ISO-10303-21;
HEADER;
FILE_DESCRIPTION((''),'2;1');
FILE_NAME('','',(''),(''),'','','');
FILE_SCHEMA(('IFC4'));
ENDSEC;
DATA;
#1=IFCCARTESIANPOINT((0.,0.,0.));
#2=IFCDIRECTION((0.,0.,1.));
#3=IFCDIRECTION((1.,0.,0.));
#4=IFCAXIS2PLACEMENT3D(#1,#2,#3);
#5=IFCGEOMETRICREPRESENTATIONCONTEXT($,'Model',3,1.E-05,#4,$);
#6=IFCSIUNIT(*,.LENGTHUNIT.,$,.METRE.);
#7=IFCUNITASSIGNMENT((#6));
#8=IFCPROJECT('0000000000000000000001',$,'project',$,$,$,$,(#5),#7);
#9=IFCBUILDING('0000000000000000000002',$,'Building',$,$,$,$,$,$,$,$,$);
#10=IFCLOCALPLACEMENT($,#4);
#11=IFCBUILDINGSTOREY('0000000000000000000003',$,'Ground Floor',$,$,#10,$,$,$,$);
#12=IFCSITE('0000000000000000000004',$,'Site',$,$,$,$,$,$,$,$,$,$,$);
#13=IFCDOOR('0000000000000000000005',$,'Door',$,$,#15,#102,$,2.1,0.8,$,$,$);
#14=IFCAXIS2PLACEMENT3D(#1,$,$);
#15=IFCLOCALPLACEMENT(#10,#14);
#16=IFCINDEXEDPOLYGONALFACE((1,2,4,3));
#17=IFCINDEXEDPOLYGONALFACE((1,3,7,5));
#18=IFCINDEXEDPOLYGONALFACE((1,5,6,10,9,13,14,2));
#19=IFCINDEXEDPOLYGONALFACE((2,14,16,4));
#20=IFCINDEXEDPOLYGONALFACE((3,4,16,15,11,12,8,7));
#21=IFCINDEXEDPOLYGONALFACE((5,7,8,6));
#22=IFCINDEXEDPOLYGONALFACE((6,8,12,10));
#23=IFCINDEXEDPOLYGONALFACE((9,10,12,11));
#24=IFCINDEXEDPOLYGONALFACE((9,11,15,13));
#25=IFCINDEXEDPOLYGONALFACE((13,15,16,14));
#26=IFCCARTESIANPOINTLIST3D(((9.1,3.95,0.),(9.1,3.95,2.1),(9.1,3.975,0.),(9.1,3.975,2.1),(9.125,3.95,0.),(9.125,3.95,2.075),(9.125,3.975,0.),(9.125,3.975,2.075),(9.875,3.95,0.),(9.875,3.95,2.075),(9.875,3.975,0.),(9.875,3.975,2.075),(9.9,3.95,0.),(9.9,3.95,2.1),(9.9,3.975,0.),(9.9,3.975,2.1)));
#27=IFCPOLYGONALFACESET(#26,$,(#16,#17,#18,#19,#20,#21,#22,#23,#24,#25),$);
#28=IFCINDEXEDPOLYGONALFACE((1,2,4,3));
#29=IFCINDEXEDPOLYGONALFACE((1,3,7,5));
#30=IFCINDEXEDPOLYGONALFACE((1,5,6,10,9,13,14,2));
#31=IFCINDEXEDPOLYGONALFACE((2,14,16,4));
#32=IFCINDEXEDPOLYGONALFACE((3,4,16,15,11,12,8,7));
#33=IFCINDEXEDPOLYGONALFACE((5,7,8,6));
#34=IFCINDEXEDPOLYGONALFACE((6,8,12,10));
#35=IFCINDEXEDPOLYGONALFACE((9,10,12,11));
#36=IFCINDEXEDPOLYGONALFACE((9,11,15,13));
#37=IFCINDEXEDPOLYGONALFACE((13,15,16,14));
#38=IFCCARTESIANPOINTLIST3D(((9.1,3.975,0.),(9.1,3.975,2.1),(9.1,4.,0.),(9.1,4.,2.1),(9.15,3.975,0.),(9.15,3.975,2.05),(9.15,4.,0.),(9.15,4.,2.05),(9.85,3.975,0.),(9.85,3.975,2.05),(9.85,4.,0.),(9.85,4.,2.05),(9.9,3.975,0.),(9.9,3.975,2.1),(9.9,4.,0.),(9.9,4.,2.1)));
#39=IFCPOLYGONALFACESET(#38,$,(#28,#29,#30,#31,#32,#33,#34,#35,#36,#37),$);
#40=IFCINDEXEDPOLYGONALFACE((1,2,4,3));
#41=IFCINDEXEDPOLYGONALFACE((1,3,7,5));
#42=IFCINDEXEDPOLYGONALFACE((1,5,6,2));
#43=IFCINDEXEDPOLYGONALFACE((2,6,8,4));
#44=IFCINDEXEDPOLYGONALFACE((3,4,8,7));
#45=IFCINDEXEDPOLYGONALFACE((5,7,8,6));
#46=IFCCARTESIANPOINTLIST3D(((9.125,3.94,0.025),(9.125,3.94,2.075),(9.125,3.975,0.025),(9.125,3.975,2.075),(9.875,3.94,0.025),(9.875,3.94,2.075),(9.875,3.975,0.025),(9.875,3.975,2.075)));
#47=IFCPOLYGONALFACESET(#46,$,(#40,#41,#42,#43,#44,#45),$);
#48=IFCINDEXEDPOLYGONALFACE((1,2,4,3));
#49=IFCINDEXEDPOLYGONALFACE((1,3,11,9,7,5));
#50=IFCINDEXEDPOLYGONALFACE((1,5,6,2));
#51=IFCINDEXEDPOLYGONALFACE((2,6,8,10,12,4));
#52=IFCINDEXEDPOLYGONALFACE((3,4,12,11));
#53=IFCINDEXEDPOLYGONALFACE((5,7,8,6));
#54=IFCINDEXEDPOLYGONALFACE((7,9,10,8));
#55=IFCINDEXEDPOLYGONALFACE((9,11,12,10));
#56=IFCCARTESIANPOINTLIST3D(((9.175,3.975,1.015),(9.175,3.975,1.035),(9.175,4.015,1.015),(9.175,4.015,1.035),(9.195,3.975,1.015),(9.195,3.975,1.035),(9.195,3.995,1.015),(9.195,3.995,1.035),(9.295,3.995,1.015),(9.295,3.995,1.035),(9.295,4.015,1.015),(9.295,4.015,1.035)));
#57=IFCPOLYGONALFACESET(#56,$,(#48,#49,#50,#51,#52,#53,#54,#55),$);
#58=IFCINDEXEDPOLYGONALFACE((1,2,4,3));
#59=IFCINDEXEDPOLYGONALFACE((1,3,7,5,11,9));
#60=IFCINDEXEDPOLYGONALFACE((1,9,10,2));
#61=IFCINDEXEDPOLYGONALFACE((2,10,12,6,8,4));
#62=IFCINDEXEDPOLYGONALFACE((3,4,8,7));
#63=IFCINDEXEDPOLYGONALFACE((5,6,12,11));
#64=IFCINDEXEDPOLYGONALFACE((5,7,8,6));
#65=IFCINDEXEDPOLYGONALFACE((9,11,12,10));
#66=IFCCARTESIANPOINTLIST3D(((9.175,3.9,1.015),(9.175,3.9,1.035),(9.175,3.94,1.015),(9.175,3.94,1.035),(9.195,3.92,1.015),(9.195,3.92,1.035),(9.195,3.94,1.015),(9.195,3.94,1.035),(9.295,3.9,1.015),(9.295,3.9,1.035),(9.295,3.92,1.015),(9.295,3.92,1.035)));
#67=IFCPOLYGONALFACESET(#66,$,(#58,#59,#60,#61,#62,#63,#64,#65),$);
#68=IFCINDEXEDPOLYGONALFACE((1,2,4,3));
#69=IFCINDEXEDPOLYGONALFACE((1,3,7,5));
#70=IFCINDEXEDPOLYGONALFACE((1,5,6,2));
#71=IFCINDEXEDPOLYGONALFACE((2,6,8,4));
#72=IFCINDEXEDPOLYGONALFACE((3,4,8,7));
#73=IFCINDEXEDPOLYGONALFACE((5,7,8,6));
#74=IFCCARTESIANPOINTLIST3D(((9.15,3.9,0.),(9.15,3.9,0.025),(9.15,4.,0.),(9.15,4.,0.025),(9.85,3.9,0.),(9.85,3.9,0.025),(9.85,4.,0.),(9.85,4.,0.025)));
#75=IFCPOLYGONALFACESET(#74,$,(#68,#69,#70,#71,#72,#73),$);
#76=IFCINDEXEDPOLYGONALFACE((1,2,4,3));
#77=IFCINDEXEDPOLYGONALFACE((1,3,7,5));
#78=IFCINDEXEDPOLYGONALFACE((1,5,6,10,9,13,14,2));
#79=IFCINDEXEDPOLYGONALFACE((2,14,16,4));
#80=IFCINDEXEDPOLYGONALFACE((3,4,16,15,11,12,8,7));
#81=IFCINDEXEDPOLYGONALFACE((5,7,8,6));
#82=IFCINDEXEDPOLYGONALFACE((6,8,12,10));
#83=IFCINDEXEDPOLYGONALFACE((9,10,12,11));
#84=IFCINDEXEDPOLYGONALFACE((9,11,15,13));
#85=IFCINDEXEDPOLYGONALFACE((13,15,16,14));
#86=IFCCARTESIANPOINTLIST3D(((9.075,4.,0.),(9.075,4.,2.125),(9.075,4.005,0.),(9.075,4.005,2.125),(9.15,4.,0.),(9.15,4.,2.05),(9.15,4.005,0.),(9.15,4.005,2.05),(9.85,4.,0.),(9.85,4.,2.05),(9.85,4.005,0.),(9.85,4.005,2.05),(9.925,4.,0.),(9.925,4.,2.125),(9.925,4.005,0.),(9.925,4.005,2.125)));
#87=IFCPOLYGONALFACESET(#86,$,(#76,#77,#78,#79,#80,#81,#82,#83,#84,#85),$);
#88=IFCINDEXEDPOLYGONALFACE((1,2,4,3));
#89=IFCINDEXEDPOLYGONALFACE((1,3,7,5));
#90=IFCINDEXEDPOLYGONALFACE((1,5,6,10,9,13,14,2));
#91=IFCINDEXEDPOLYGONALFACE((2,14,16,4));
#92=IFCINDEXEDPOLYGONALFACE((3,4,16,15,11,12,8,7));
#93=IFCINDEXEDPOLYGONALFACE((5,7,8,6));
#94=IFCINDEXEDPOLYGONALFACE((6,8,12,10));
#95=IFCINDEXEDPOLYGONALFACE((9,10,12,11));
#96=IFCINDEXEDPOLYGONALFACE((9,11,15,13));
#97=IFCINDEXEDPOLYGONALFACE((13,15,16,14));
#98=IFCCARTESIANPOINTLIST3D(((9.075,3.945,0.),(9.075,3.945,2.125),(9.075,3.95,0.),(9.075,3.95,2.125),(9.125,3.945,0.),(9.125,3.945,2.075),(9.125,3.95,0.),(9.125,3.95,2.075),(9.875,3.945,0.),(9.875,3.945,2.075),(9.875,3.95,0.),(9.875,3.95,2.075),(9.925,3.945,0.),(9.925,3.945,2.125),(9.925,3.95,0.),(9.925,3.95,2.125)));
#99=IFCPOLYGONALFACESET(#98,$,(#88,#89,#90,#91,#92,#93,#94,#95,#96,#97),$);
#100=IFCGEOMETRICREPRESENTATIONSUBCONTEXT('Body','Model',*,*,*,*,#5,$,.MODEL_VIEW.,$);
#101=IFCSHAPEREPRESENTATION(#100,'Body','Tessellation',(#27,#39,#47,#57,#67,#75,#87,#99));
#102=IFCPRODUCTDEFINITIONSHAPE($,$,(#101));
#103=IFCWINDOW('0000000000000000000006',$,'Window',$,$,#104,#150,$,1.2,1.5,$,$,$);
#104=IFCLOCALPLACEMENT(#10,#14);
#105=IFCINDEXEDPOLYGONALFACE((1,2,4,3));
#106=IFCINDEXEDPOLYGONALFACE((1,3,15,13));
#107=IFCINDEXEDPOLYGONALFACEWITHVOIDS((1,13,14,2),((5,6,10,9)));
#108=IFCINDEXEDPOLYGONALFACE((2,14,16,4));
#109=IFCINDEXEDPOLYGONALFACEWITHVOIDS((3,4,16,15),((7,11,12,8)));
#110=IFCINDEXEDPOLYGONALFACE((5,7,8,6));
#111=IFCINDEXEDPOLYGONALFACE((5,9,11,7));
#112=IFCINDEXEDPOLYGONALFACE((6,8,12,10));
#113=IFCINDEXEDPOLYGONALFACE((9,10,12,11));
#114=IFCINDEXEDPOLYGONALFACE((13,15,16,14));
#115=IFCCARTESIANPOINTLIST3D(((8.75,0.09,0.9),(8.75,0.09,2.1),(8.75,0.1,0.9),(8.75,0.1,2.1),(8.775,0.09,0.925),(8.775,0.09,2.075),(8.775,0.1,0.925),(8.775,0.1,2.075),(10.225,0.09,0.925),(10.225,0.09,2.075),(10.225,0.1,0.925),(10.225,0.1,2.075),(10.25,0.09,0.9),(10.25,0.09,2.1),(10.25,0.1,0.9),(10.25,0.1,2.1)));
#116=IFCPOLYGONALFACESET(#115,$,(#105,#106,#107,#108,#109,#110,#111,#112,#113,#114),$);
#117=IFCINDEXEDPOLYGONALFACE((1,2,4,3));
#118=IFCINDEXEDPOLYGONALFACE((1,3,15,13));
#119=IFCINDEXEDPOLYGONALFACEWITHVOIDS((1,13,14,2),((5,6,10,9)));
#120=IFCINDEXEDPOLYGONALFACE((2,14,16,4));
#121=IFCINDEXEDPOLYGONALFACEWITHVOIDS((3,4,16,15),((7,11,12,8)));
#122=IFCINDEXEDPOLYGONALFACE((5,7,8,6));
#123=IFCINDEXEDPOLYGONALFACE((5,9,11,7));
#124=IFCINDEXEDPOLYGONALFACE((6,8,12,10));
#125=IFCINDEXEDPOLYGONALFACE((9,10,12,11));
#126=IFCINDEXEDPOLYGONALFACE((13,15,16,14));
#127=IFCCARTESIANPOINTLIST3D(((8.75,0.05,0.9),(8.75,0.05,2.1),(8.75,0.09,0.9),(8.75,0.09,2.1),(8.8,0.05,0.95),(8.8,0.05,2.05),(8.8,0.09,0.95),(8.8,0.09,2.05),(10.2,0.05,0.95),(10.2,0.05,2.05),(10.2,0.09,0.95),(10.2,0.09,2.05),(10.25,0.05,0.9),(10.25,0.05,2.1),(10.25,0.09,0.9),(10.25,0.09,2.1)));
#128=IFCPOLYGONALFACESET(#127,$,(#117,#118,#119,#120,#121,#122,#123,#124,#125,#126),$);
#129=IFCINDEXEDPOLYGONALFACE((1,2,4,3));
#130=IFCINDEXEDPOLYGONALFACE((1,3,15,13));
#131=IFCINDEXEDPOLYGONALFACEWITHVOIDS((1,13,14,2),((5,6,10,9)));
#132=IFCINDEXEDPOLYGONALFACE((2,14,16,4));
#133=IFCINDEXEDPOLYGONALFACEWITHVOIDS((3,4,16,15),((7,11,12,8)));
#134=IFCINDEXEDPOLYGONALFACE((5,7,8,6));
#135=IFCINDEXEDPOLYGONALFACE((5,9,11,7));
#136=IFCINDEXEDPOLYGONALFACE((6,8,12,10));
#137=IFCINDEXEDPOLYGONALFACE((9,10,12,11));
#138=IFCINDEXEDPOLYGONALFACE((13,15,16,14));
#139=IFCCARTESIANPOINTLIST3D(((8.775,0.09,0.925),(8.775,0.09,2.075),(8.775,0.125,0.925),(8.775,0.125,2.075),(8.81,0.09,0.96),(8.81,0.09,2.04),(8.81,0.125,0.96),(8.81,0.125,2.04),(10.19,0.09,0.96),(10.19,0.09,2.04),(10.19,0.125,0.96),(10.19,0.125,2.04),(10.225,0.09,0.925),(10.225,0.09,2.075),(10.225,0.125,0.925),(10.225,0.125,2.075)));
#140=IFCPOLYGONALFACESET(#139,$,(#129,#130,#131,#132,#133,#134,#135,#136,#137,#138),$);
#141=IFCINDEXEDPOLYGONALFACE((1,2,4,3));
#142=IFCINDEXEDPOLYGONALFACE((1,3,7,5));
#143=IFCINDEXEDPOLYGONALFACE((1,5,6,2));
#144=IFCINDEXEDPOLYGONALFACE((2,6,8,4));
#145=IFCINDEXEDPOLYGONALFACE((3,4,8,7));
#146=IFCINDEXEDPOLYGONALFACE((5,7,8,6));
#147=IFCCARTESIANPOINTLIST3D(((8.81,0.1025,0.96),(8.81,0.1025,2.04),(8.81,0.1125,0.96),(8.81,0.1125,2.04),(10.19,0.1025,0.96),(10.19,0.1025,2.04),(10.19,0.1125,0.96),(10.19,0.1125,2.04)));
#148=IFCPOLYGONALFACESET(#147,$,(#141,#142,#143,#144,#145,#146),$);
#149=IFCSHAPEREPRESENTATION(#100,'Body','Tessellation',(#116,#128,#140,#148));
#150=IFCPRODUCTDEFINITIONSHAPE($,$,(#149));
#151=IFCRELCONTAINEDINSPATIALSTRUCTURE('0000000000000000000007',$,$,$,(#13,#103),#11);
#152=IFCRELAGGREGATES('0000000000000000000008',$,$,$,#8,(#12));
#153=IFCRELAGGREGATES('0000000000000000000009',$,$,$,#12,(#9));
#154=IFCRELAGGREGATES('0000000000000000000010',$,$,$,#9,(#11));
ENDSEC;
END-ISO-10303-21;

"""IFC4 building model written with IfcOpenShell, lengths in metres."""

from ifc_helpers import new_model, si_unit, frame, origin_with_axes, place, context, subcontext, project, spatial, line, indexed_curve, outline, extrude, element, save


model = new_model("IFC4")

# Units and contexts
model_context = context("Model", 3, precision=1e-05, world=origin_with_axes())
body_context = subcontext(model_context, "Body", "Model", "MODEL_VIEW")
ifc_project = project(units=[si_unit("LENGTHUNIT", "METRE")], contexts=[model_context])

# Site, building, storey
site = spatial("IfcSite", under=ifc_project, Name="Site")
building = spatial("IfcBuilding", under=site, Name="Building")
storey_placement = place(None, origin_with_axes())
storey = spatial("IfcBuildingStorey", under=building, at=storey_placement, Name="Ground Floor")

# Door
door_1_placement = place(storey_placement, frame((9.9, 4.0, 0.0), z_axis=(0.0, 0.0, 1.0), x_axis=(-1.0, 0.0, 0.0)))
element("IfcDoor", 1, at=door_1_placement, inside=storey, Name="Door", OverallHeight=2.1, OverallWidth=0.8, context=body_context, shape_type="SweptSolid", body=[
    extrude(outline(indexed_curve([(0.0, 0.0), (0.0, 2.1), (0.8, 2.1), (0.8, 0.0), (0.775, 0.0), (0.775, 2.075), (0.025, 2.075), (0.025, 0.0)], segments=[line(1, 2, 3, 4, 5, 6, 7, 8, 1)])), frame((0.0, 0.025, 0.0), z_axis=(0.0, -1.0, 0.0), x_axis=(1.0, 0.0, 0.0)), (0.0, 0.0, -1.0), 0.025),
    extrude(outline(indexed_curve([(0.0, 0.0), (0.0, 2.1), (0.8, 2.1), (0.8, 0.0), (0.75, 0.0), (0.75, 2.05), (0.05, 2.05), (0.05, 0.0)], segments=[line(1, 2, 3, 4, 5, 6, 7, 8, 1)])), frame((0.0, 0.0, 0.0), z_axis=(0.0, -1.0, 0.0), x_axis=(1.0, 0.0, 0.0)), (0.0, 0.0, -1.0), 0.025),
    extrude(outline(indexed_curve([(0.0, 0.0), (0.75, 0.0), (0.75, 0.035), (0.0, 0.035)], segments=[line(1, 2, 3, 4, 1)])), frame((0.025, 0.025, 0.025), z_axis=(0.0, 0.0, 1.0), x_axis=(1.0, 0.0, 0.0)), (0.0, 0.0, 1.0), 2.05),
    extrude(outline(indexed_curve([(0.0, 0.0), (0.0, -0.04), (-0.12, -0.04), (-0.12, -0.02), (-0.02, -0.02), (-0.02, 0.0)], segments=[line(1, 2, 3, 4, 5, 6, 1)])), frame((0.725, 0.025, 1.015), z_axis=(0.0, 0.0, 1.0), x_axis=(1.0, 0.0, 0.0)), (0.0, 0.0, 1.0), 0.02),
    extrude(outline(indexed_curve([(0.0, 0.0), (0.0, 0.04), (-0.12, 0.04), (-0.12, 0.02), (-0.02, 0.02), (-0.02, 0.0)], segments=[line(1, 2, 3, 4, 5, 6, 1)])), frame((0.725, 0.06, 1.015), z_axis=(0.0, 0.0, 1.0), x_axis=(1.0, 0.0, 0.0)), (0.0, 0.0, 1.0), 0.02),
    extrude(outline(indexed_curve([(0.0, 0.0), (0.7, 0.0), (0.7, 0.1), (0.0, 0.1)], segments=[line(1, 2, 3, 4, 1)])), frame((0.05, 0.0, 0.0), z_axis=(0.0, 0.0, 1.0), x_axis=(1.0, 0.0, 0.0)), (0.0, 0.0, 1.0), 0.025),
    extrude(outline(indexed_curve([(0.0, 0.0), (0.0, 2.125), (0.85, 2.125), (0.85, 0.0), (0.775, 0.0), (0.775, 2.05), (0.075, 2.05), (0.075, 0.0)], segments=[line(1, 2, 3, 4, 5, 6, 7, 8, 1)])), frame((-0.025, -0.005, 0.0), z_axis=(0.0, -1.0, 0.0), x_axis=(1.0, 0.0, 0.0)), (0.0, 0.0, -1.0), 0.005),
    extrude(outline(indexed_curve([(0.0, 0.0), (0.0, 2.125), (0.85, 2.125), (0.85, 0.0), (0.8, 0.0), (0.8, 2.075), (0.05, 2.075), (0.05, 0.0)], segments=[line(1, 2, 3, 4, 5, 6, 7, 8, 1)])), frame((-0.025, 0.05, 0.0), z_axis=(0.0, -1.0, 0.0), x_axis=(1.0, 0.0, 0.0)), (0.0, 0.0, -1.0), 0.005),
])

# Window
window_placement = place(storey_placement, frame((8.75, 0.0, 0.9), z_axis=(0.0, 0.0, 1.0), x_axis=(1.0, 0.0, 0.0)))
element("IfcWindow", 2, at=window_placement, inside=storey, Name="Window", OverallHeight=1.2, OverallWidth=1.5, context=body_context, shape_type="SweptSolid", body=[
    extrude(outline(indexed_curve([(0.0, 0.0), (1.5, 0.0), (1.5, 1.2), (0.0, 1.2)], segments=[line(1, 2, 3, 4, 1)]), holes=[indexed_curve([(0.025, 0.025), (1.475, 0.025), (1.475, 1.175), (0.025, 1.175)], segments=[line(1, 2, 3, 4, 1)])]), frame((0.0, 0.09, 0.0), z_axis=(0.0, -1.0, 0.0), x_axis=(1.0, 0.0, 0.0)), (0.0, 0.0, -1.0), 0.01),
    extrude(outline(indexed_curve([(0.0, 0.0), (1.5, 0.0), (1.5, 1.2), (0.0, 1.2)], segments=[line(1, 2, 3, 4, 1)]), holes=[indexed_curve([(0.05, 0.05), (1.45, 0.05), (1.45, 1.15), (0.05, 1.15)], segments=[line(1, 2, 3, 4, 1)])]), frame((0.0, 0.05, 0.0), z_axis=(0.0, -1.0, 0.0), x_axis=(1.0, 0.0, 0.0)), (0.0, 0.0, -1.0), 0.04),
    extrude(outline(indexed_curve([(0.0, 0.0), (1.45, 0.0), (1.45, 1.15), (0.0, 1.15)], segments=[line(1, 2, 3, 4, 1)]), holes=[indexed_curve([(0.035, 0.035), (1.415, 0.035), (1.415, 1.115), (0.035, 1.115)], segments=[line(1, 2, 3, 4, 1)])]), frame((0.025, 0.09, 0.025), z_axis=(0.0, -1.0, 0.0), x_axis=(1.0, 0.0, 0.0)), (0.0, 0.0, -1.0), 0.035),
    extrude(outline(indexed_curve([(0.035, 0.035), (1.415, 0.035), (1.415, 1.115), (0.035, 1.115)], segments=[line(1, 2, 3, 4, 1)])), frame((0.025, 0.1025, 0.025), z_axis=(0.0, -1.0, 0.0), x_axis=(1.0, 0.0, 0.0)), (0.0, 0.0, -1.0), 0.01),
])

save(model, "model.ifc")
